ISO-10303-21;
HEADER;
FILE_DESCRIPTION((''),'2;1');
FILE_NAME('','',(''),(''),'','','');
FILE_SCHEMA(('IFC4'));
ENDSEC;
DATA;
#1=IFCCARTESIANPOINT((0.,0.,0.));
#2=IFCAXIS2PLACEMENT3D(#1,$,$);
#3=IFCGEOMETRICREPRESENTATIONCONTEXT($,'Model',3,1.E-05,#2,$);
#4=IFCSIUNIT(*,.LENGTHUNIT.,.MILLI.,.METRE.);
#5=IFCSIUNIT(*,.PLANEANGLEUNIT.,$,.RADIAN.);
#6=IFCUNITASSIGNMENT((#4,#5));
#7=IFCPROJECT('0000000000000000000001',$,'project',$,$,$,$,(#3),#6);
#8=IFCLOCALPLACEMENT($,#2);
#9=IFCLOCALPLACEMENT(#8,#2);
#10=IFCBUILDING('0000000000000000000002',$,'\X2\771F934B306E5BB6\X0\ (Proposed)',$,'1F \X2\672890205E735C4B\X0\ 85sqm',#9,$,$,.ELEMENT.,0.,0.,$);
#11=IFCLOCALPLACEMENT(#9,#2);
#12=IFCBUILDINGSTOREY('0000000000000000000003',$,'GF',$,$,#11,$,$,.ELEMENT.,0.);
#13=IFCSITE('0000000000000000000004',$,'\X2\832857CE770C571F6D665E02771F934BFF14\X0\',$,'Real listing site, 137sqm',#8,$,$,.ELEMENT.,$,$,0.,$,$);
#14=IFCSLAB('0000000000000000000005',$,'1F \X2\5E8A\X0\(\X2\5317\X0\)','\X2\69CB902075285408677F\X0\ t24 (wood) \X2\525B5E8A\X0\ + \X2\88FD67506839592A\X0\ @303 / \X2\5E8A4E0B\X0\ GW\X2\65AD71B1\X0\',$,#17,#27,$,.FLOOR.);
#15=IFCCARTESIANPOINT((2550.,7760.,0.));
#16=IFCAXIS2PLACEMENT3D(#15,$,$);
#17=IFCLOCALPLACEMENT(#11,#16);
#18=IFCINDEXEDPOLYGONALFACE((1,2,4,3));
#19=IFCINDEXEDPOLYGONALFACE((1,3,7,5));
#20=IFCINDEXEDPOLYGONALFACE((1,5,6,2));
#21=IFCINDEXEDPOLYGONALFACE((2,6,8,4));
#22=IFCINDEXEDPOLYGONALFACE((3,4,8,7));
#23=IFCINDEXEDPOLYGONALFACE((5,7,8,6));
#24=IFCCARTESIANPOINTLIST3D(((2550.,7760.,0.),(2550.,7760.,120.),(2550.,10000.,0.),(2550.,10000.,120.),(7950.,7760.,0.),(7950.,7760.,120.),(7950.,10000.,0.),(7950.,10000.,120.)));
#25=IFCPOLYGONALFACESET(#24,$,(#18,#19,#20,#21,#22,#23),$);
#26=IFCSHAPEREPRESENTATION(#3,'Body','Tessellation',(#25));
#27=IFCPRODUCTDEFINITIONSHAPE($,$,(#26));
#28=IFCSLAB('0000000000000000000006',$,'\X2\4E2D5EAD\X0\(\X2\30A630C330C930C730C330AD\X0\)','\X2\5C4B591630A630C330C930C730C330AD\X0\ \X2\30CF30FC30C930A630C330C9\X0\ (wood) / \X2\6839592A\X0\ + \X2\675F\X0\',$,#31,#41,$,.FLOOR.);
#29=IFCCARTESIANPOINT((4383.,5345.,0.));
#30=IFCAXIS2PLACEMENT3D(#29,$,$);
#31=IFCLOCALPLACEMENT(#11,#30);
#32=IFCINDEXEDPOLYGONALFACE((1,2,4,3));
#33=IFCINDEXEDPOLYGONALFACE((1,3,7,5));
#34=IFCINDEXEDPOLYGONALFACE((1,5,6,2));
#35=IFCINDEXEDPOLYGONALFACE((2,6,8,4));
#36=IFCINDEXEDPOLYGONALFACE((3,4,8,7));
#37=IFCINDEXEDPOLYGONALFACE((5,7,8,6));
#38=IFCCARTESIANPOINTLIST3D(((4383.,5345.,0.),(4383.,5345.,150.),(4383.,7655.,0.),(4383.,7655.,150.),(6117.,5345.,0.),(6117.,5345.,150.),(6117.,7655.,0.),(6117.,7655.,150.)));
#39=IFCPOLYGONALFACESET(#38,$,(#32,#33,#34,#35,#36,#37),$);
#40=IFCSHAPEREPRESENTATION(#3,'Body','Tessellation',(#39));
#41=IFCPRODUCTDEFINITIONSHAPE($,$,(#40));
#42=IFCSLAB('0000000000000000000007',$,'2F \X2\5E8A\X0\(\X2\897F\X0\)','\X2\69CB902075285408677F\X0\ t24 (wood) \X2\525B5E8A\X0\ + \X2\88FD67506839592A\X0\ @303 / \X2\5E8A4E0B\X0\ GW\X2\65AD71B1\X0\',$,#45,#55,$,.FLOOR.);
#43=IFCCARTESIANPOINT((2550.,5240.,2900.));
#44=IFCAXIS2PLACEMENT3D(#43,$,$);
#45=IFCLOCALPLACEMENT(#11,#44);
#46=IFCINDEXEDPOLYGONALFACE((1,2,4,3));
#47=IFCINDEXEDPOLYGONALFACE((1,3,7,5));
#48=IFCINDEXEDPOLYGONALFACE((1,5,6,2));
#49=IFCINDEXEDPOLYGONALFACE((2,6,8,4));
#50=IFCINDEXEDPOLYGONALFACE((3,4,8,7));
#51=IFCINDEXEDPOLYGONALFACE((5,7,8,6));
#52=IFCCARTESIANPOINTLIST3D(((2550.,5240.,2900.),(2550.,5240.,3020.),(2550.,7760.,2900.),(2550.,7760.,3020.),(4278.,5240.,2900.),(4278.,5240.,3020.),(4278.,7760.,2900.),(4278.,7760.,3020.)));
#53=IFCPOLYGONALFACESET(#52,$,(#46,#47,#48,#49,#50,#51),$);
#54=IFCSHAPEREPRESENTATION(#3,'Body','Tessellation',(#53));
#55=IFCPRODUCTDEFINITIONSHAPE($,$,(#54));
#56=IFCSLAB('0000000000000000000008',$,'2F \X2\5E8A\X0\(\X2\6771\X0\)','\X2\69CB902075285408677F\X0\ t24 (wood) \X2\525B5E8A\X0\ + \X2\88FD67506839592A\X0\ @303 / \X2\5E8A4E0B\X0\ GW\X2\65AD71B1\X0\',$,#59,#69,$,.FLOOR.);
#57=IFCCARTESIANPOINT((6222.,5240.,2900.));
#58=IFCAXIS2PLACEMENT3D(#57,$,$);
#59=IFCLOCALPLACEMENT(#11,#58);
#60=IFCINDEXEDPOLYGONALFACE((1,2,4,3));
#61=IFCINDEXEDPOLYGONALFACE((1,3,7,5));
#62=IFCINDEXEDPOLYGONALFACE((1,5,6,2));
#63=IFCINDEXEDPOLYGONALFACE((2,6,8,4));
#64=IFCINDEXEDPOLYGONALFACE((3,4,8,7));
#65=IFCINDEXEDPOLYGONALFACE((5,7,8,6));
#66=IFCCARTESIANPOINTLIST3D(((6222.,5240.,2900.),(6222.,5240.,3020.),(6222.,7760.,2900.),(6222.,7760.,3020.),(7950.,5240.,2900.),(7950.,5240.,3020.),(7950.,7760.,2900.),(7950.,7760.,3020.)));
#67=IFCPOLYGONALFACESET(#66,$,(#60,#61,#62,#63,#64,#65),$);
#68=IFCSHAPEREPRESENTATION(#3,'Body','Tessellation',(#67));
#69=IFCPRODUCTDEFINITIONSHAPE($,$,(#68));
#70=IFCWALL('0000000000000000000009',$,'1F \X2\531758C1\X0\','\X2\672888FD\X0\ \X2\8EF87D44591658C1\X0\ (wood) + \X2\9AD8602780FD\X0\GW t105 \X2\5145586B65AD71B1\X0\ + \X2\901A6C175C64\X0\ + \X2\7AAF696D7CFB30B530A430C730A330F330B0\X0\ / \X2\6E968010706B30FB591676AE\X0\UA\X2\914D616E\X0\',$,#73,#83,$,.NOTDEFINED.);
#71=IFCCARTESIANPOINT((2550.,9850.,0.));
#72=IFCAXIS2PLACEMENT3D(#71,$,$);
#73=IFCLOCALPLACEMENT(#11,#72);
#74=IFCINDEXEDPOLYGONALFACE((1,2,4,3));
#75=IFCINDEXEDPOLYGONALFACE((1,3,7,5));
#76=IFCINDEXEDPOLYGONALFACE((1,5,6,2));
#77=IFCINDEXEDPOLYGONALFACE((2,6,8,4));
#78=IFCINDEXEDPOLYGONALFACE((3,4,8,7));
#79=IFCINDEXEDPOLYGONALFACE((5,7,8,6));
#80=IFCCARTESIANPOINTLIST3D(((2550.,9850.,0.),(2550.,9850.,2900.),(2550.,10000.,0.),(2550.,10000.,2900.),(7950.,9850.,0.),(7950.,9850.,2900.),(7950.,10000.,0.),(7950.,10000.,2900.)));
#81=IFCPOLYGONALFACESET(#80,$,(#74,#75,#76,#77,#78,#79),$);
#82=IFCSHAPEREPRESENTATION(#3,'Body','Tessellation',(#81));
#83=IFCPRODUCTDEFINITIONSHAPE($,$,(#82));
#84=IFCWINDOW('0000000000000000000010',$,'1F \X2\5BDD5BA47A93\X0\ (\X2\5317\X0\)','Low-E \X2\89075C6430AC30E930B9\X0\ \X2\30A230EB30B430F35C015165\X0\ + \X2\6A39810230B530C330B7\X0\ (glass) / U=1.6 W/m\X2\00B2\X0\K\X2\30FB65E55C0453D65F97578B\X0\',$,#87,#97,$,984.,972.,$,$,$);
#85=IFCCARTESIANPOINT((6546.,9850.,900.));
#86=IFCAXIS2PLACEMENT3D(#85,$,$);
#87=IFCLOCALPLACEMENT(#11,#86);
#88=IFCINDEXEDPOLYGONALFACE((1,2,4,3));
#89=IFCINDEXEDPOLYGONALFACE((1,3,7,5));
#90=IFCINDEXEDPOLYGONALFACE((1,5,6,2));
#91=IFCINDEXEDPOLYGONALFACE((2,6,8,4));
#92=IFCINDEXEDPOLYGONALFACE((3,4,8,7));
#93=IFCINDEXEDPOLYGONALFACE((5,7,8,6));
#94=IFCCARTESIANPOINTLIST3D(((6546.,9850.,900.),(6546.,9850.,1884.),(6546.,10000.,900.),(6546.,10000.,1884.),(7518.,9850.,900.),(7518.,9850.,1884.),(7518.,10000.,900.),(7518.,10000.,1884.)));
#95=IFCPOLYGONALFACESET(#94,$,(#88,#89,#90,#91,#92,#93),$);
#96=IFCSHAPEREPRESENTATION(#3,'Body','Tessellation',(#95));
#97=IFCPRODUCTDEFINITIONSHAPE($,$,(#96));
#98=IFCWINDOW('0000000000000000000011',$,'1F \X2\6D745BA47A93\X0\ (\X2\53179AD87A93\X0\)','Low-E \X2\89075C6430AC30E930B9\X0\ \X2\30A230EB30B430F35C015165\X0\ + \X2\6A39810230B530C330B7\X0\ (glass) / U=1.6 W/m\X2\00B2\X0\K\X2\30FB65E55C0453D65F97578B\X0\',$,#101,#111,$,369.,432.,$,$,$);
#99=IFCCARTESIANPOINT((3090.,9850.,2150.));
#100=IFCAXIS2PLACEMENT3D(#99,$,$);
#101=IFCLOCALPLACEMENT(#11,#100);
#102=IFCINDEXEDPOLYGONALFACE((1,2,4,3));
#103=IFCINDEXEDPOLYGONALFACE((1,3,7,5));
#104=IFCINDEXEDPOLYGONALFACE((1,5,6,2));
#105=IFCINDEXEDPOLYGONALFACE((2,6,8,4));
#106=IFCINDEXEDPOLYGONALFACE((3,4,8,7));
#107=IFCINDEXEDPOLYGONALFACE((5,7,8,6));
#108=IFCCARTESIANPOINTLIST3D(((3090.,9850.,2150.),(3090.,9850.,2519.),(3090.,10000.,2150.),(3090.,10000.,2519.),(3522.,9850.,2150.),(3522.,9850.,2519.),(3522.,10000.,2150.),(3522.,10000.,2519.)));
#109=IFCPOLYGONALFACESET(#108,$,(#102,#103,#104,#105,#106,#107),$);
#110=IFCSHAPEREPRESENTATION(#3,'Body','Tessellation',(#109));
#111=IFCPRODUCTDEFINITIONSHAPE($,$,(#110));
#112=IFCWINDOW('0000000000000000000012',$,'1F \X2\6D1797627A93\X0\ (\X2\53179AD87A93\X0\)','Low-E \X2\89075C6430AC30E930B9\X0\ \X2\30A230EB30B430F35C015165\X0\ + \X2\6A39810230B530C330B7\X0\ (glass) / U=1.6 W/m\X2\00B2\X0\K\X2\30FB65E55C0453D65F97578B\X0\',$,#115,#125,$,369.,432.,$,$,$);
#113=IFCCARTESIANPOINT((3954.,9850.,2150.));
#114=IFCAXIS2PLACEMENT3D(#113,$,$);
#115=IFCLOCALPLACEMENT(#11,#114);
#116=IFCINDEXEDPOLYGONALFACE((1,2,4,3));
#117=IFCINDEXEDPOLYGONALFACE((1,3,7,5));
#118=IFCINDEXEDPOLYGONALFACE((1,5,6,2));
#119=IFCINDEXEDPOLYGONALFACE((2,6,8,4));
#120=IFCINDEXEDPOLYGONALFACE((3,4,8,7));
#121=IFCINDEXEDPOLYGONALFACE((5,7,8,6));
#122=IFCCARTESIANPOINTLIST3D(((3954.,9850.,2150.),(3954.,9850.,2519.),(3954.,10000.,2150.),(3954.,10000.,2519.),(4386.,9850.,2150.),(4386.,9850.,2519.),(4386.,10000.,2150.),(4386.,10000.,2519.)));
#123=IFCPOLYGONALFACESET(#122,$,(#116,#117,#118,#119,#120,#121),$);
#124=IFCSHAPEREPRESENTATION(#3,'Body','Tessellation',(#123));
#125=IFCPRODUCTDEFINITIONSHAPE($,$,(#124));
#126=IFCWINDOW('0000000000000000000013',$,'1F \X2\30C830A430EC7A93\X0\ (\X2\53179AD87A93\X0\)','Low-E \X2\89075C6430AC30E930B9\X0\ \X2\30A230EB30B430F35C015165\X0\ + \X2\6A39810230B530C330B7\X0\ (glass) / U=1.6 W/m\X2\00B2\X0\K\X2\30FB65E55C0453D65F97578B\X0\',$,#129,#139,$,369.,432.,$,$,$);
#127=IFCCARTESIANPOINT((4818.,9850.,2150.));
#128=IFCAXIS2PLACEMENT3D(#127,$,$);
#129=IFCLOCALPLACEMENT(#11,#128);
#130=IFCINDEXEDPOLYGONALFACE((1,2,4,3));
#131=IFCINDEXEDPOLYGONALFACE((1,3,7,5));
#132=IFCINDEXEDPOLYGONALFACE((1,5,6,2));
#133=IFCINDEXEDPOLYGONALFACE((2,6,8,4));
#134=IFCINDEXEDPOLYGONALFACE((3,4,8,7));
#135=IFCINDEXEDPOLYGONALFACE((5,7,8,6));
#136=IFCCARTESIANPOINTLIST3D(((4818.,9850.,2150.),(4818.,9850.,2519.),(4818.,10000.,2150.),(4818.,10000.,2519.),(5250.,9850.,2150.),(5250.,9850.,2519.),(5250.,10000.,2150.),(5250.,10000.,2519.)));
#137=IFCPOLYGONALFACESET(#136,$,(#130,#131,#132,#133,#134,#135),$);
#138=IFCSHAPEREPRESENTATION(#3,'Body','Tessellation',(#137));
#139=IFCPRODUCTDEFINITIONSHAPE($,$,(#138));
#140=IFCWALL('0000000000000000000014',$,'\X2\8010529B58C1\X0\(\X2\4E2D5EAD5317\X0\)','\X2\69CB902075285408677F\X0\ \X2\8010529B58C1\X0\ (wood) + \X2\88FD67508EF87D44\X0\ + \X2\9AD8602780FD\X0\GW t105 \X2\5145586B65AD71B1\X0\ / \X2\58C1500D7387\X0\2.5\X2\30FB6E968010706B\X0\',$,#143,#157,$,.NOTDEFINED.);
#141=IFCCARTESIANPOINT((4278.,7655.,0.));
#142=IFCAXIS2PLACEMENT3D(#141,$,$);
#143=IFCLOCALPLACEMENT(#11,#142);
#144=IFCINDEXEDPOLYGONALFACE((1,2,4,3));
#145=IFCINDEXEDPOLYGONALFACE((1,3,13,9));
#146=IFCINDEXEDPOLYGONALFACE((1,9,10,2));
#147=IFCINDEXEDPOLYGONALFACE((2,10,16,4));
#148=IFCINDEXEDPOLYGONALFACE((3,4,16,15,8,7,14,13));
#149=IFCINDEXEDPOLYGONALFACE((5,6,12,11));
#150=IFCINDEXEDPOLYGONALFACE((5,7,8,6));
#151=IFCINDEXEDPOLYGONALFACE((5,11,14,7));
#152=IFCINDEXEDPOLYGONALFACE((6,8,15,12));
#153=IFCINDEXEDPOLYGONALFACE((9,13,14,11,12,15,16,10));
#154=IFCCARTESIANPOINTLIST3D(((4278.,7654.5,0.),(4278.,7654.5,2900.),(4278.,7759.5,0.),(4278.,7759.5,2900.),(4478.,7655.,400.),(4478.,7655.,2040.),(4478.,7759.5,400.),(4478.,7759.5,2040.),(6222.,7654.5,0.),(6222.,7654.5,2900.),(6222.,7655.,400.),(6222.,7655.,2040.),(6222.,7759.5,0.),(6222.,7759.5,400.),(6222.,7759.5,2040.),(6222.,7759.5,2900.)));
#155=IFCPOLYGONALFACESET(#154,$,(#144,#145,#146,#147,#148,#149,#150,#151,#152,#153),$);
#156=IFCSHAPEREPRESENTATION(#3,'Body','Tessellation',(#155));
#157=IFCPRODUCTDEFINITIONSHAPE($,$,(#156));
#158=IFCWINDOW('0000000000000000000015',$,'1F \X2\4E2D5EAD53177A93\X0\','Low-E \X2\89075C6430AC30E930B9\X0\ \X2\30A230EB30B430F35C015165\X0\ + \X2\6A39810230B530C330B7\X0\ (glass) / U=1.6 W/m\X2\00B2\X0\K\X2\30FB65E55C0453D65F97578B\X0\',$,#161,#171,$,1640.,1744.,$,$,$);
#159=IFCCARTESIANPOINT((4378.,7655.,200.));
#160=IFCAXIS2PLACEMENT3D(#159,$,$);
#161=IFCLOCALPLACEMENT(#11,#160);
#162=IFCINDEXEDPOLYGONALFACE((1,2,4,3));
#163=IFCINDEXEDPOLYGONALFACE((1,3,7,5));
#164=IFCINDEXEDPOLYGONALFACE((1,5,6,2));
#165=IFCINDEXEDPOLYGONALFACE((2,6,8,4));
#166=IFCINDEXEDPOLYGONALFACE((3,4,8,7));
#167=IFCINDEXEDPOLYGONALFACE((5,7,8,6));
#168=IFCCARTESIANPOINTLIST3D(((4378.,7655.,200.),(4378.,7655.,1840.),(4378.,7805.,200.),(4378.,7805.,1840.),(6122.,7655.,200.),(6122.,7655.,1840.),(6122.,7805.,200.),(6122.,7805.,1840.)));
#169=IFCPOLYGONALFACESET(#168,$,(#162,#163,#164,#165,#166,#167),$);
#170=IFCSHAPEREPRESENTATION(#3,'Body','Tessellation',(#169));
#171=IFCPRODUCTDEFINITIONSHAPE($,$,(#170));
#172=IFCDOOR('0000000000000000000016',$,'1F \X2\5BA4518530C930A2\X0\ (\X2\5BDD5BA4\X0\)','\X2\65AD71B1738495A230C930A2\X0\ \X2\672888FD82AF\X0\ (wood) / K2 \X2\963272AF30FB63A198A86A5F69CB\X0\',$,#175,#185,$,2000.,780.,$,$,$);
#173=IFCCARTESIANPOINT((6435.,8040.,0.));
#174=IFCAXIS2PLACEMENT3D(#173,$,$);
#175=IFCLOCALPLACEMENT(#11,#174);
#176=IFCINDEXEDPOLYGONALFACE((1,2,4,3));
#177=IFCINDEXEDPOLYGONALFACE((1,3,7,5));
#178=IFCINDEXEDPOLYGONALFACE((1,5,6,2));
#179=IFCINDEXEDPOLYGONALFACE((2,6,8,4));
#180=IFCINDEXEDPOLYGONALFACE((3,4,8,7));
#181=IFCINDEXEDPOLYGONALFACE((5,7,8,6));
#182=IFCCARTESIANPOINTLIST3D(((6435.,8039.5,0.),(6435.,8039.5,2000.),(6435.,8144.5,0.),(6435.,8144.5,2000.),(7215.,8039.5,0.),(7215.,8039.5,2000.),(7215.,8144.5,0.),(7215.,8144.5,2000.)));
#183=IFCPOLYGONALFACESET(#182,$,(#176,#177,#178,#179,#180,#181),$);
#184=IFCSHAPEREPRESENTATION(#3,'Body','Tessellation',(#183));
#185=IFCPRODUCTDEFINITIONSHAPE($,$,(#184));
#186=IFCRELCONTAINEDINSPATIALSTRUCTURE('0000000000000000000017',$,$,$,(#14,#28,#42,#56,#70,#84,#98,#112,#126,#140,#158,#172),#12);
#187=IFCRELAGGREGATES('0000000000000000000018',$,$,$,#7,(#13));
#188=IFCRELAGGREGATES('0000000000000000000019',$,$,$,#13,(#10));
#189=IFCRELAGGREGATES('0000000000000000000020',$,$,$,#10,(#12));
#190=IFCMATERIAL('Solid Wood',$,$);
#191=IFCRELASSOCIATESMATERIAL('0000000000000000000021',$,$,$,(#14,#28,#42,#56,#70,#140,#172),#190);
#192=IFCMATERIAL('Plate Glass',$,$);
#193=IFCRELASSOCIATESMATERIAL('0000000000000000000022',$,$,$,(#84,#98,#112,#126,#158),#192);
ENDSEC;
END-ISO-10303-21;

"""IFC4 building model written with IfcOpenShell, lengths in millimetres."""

from ifc_helpers import new_model, si_unit, frame, frame_2d, origin, place, context, project, spatial, rectangle, extrude, material, element, fill, save


model = new_model("IFC4")

# Units and contexts
model_context = context("Model", 3, precision=1e-05, world=origin())
ifc_project = project(units=[si_unit("LENGTHUNIT", "METRE", prefix="MILLI"), si_unit("PLANEANGLEUNIT", "RADIAN")], contexts=[model_context])

# Site, building, storey
site_placement = place(None, origin())
site = spatial("IfcSite", under=ifc_project, at=site_placement, Name="茨城県土浦市真鍋４", ObjectType="Real listing site, 137sqm", CompositionType="ELEMENT", RefElevation=0.0)
building_placement = place(site_placement, origin())
building = spatial("IfcBuilding", under=site, at=building_placement, Name="真鍋の家 (Proposed)", ObjectType="1F 木造平屋 85sqm", CompositionType="ELEMENT", ElevationOfRefHeight=0.0, ElevationOfTerrain=0.0)
storey_placement = place(building_placement, origin())
storey = spatial("IfcBuildingStorey", under=building, at=storey_placement, Name="GF", CompositionType="ELEMENT", Elevation=0.0)

# Slabs
ifc_material_1 = material(Name="Solid Wood")
slab_1_placement = place(storey_placement, frame((2550.0, 7760.0, 0.0)))
element("IfcSlab", 1, at=slab_1_placement, inside=storey, material=ifc_material_1, Name="1F 床(北)", Description="構造用合板 t24 (wood) 剛床 + 製材根太 @303 / 床下 GW断熱", PredefinedType="FLOOR", context=model_context, shape_type="SweptSolid", body=[
    extrude(rectangle(XDim=5400.0, YDim=2240.0, at=frame_2d((2700.0, 1120.0))), frame((2550.0, 7760.0, 0.0)), (0.0, 0.0, 1.0), 120.0),
])
slab_2_placement = place(storey_placement, frame((4383.0, 5345.0, 0.0)))
element("IfcSlab", 2, at=slab_2_placement, inside=storey, material=ifc_material_1, Name="中庭(ウッドデッキ)", Description="屋外ウッドデッキ ハードウッド (wood) / 根太 + 束", PredefinedType="FLOOR", context=model_context, shape_type="SweptSolid", body=[
    extrude(rectangle(XDim=1734.0, YDim=2310.0, at=frame_2d((867.0, 1155.0))), frame((4383.0, 5345.0, 0.0)), (0.0, 0.0, 1.0), 150.0),
])
slab_3_placement = place(storey_placement, frame((2550.0, 5240.0, 2900.0)))
element("IfcSlab", 3, at=slab_3_placement, inside=storey, material=ifc_material_1, Name="2F 床(西)", Description="構造用合板 t24 (wood) 剛床 + 製材根太 @303 / 床下 GW断熱", PredefinedType="FLOOR", context=model_context, shape_type="SweptSolid", body=[
    extrude(rectangle(XDim=1728.0, YDim=2520.0, at=frame_2d((864.0, 1260.0))), frame((2550.0, 5240.0, 2900.0)), (0.0, 0.0, 1.0), 120.0),
])
slab_4_placement = place(storey_placement, frame((6222.0, 5240.0, 2900.0)))
element("IfcSlab", 4, at=slab_4_placement, inside=storey, material=ifc_material_1, Name="2F 床(東)", Description="構造用合板 t24 (wood) 剛床 + 製材根太 @303 / 床下 GW断熱", PredefinedType="FLOOR", context=model_context, shape_type="SweptSolid", body=[
    extrude(rectangle(XDim=1728.0, YDim=2520.0, at=frame_2d((864.0, 1260.0))), frame((6222.0, 5240.0, 2900.0)), (0.0, 0.0, 1.0), 120.0),
])

# Wall, openings, windows
wall_1_placement = place(storey_placement, frame((2550.0, 9850.0, 0.0)))
wall_1 = element("IfcWall", 5, at=wall_1_placement, inside=storey, material=ifc_material_1, Name="1F 北壁", Description="木製 軸組外壁 (wood) + 高性能GW t105 充填断熱 + 通気層 + 窯業系サイディング / 準耐火・外皮UA配慮", PredefinedType="NOTDEFINED", context=model_context, shape_type="SweptSolid", body=[
    extrude(rectangle(XDim=5400.0, YDim=150.0, at=frame_2d((2700.0, 75.0))), frame((2550.0, 9850.0, 0.0)), (0.0, 0.0, 1.0), 2900.0),
])
opening_1_placement = place(storey_placement, frame((6546.0, 9850.0, 900.0)))
opening_1 = element("IfcOpeningElement", 6, at=opening_1_placement, cuts=wall_1, PredefinedType="NOTDEFINED", context=model_context, shape_type="SweptSolid", body=[
    extrude(rectangle(XDim=972.0, YDim=150.0, at=frame_2d((486.0, 75.0))), frame((6546.0, 9850.0, 900.0)), (0.0, 0.0, 1.0), 984.0),
])
opening_2_placement = place(storey_placement, frame((3090.0, 9850.0, 2150.0)))
opening_2 = element("IfcOpeningElement", 7, at=opening_2_placement, cuts=wall_1, PredefinedType="NOTDEFINED", context=model_context, shape_type="SweptSolid", body=[
    extrude(rectangle(XDim=432.0, YDim=150.0, at=frame_2d((216.0, 75.0))), frame((3090.0, 9850.0, 2150.0)), (0.0, 0.0, 1.0), 369.0),
])
opening_3_placement = place(storey_placement, frame((3954.0, 9850.0, 2150.0)))
opening_3 = element("IfcOpeningElement", 8, at=opening_3_placement, cuts=wall_1, PredefinedType="NOTDEFINED", context=model_context, shape_type="SweptSolid", body=[
    extrude(rectangle(XDim=432.0, YDim=150.0, at=frame_2d((216.0, 75.0))), frame((3954.0, 9850.0, 2150.0)), (0.0, 0.0, 1.0), 369.0),
])
opening_4_placement = place(storey_placement, frame((4818.0, 9850.0, 2150.0)))
opening_4 = element("IfcOpeningElement", 9, at=opening_4_placement, cuts=wall_1, PredefinedType="NOTDEFINED", context=model_context, shape_type="SweptSolid", body=[
    extrude(rectangle(XDim=432.0, YDim=150.0, at=frame_2d((216.0, 75.0))), frame((4818.0, 9850.0, 2150.0)), (0.0, 0.0, 1.0), 369.0),
])
ifc_material_2 = material(Name="Plate Glass")
window_1_placement = place(storey_placement, frame((6546.0, 9850.0, 900.0)))
window_1 = element("IfcWindow", 10, at=window_1_placement, inside=storey, material=ifc_material_2, Name="1F 寝室窓 (北)", Description="Low-E 複層ガラス アルゴン封入 + 樹脂サッシ (glass) / U=1.6 W/m²K・日射取得型", OverallHeight=984.0, OverallWidth=972.0, context=model_context, shape_type="SweptSolid", body=[
    extrude(rectangle(XDim=972.0, YDim=150.0, at=frame_2d((486.0, 75.0))), frame((6546.0, 9850.0, 900.0)), (0.0, 0.0, 1.0), 984.0),
])
fill(opening_1, window_1)
window_2_placement = place(storey_placement, frame((3090.0, 9850.0, 2150.0)))
window_2 = element("IfcWindow", 11, at=window_2_placement, inside=storey, material=ifc_material_2, Name="1F 浴室窓 (北高窓)", Description="Low-E 複層ガラス アルゴン封入 + 樹脂サッシ (glass) / U=1.6 W/m²K・日射取得型", OverallHeight=369.0, OverallWidth=432.0, context=model_context, shape_type="SweptSolid", body=[
    extrude(rectangle(XDim=432.0, YDim=150.0, at=frame_2d((216.0, 75.0))), frame((3090.0, 9850.0, 2150.0)), (0.0, 0.0, 1.0), 369.0),
])
fill(opening_2, window_2)
window_3_placement = place(storey_placement, frame((3954.0, 9850.0, 2150.0)))
window_3 = element("IfcWindow", 12, at=window_3_placement, inside=storey, material=ifc_material_2, Name="1F 洗面窓 (北高窓)", Description="Low-E 複層ガラス アルゴン封入 + 樹脂サッシ (glass) / U=1.6 W/m²K・日射取得型", OverallHeight=369.0, OverallWidth=432.0, context=model_context, shape_type="SweptSolid", body=[
    extrude(rectangle(XDim=432.0, YDim=150.0, at=frame_2d((216.0, 75.0))), frame((3954.0, 9850.0, 2150.0)), (0.0, 0.0, 1.0), 369.0),
])
fill(opening_3, window_3)
window_4_placement = place(storey_placement, frame((4818.0, 9850.0, 2150.0)))
window_4 = element("IfcWindow", 13, at=window_4_placement, inside=storey, material=ifc_material_2, Name="1F トイレ窓 (北高窓)", Description="Low-E 複層ガラス アルゴン封入 + 樹脂サッシ (glass) / U=1.6 W/m²K・日射取得型", OverallHeight=369.0, OverallWidth=432.0, context=model_context, shape_type="SweptSolid", body=[
    extrude(rectangle(XDim=432.0, YDim=150.0, at=frame_2d((216.0, 75.0))), frame((4818.0, 9850.0, 2150.0)), (0.0, 0.0, 1.0), 369.0),
])
fill(opening_4, window_4)

# Wall, opening, window
wall_2_placement = place(storey_placement, frame((4278.0, 7655.0, 0.0)))
wall_2 = element("IfcWall", 14, at=wall_2_placement, inside=storey, material=ifc_material_1, Name="耐力壁(中庭北)", Description="構造用合板 耐力壁 (wood) + 製材軸組 + 高性能GW t105 充填断熱 / 壁倍率2.5・準耐火", PredefinedType="NOTDEFINED", context=model_context, shape_type="SweptSolid", body=[
    extrude(rectangle(XDim=1944.0, YDim=105.0, at=frame_2d((972.0, 52.0))), frame((4278.0, 7655.0, 0.0)), (0.0, 0.0, 1.0), 2900.0),
])
opening_5_placement = place(storey_placement, frame((4378.0, 7655.0, 200.0)))
opening_5 = element("IfcOpeningElement", 15, at=opening_5_placement, cuts=wall_2, PredefinedType="NOTDEFINED", context=model_context, shape_type="SweptSolid", body=[
    extrude(rectangle(XDim=1744.0, YDim=150.0, at=frame_2d((872.0, 75.0))), frame((4378.0, 7655.0, 200.0)), (0.0, 0.0, 1.0), 1640.0),
])
window_5_placement = place(storey_placement, frame((4378.0, 7655.0, 200.0)))
window_5 = element("IfcWindow", 16, at=window_5_placement, inside=storey, material=ifc_material_2, Name="1F 中庭北窓", Description="Low-E 複層ガラス アルゴン封入 + 樹脂サッシ (glass) / U=1.6 W/m²K・日射取得型", OverallHeight=1640.0, OverallWidth=1744.0, context=model_context, shape_type="SweptSolid", body=[
    extrude(rectangle(XDim=1744.0, YDim=150.0, at=frame_2d((872.0, 75.0))), frame((4378.0, 7655.0, 200.0)), (0.0, 0.0, 1.0), 1640.0),
])
fill(opening_5, window_5)

# Door
door_1_placement = place(storey_placement, frame((6435.0, 8040.0, 0.0)))
element("IfcDoor", 17, at=door_1_placement, inside=storey, material=ifc_material_1, Name="1F 室内ドア (寝室)", Description="断熱玄関ドア 木製芯 (wood) / K2 防犯・採風機構", OverallHeight=2000.0, OverallWidth=780.0, context=model_context, shape_type="SweptSolid", body=[
    extrude(rectangle(XDim=780.0, YDim=105.0, at=frame_2d((390.0, 52.0))), frame((6435.0, 8040.0, 0.0)), (0.0, 0.0, 1.0), 2000.0),
])

save(model, "model.ifc")
